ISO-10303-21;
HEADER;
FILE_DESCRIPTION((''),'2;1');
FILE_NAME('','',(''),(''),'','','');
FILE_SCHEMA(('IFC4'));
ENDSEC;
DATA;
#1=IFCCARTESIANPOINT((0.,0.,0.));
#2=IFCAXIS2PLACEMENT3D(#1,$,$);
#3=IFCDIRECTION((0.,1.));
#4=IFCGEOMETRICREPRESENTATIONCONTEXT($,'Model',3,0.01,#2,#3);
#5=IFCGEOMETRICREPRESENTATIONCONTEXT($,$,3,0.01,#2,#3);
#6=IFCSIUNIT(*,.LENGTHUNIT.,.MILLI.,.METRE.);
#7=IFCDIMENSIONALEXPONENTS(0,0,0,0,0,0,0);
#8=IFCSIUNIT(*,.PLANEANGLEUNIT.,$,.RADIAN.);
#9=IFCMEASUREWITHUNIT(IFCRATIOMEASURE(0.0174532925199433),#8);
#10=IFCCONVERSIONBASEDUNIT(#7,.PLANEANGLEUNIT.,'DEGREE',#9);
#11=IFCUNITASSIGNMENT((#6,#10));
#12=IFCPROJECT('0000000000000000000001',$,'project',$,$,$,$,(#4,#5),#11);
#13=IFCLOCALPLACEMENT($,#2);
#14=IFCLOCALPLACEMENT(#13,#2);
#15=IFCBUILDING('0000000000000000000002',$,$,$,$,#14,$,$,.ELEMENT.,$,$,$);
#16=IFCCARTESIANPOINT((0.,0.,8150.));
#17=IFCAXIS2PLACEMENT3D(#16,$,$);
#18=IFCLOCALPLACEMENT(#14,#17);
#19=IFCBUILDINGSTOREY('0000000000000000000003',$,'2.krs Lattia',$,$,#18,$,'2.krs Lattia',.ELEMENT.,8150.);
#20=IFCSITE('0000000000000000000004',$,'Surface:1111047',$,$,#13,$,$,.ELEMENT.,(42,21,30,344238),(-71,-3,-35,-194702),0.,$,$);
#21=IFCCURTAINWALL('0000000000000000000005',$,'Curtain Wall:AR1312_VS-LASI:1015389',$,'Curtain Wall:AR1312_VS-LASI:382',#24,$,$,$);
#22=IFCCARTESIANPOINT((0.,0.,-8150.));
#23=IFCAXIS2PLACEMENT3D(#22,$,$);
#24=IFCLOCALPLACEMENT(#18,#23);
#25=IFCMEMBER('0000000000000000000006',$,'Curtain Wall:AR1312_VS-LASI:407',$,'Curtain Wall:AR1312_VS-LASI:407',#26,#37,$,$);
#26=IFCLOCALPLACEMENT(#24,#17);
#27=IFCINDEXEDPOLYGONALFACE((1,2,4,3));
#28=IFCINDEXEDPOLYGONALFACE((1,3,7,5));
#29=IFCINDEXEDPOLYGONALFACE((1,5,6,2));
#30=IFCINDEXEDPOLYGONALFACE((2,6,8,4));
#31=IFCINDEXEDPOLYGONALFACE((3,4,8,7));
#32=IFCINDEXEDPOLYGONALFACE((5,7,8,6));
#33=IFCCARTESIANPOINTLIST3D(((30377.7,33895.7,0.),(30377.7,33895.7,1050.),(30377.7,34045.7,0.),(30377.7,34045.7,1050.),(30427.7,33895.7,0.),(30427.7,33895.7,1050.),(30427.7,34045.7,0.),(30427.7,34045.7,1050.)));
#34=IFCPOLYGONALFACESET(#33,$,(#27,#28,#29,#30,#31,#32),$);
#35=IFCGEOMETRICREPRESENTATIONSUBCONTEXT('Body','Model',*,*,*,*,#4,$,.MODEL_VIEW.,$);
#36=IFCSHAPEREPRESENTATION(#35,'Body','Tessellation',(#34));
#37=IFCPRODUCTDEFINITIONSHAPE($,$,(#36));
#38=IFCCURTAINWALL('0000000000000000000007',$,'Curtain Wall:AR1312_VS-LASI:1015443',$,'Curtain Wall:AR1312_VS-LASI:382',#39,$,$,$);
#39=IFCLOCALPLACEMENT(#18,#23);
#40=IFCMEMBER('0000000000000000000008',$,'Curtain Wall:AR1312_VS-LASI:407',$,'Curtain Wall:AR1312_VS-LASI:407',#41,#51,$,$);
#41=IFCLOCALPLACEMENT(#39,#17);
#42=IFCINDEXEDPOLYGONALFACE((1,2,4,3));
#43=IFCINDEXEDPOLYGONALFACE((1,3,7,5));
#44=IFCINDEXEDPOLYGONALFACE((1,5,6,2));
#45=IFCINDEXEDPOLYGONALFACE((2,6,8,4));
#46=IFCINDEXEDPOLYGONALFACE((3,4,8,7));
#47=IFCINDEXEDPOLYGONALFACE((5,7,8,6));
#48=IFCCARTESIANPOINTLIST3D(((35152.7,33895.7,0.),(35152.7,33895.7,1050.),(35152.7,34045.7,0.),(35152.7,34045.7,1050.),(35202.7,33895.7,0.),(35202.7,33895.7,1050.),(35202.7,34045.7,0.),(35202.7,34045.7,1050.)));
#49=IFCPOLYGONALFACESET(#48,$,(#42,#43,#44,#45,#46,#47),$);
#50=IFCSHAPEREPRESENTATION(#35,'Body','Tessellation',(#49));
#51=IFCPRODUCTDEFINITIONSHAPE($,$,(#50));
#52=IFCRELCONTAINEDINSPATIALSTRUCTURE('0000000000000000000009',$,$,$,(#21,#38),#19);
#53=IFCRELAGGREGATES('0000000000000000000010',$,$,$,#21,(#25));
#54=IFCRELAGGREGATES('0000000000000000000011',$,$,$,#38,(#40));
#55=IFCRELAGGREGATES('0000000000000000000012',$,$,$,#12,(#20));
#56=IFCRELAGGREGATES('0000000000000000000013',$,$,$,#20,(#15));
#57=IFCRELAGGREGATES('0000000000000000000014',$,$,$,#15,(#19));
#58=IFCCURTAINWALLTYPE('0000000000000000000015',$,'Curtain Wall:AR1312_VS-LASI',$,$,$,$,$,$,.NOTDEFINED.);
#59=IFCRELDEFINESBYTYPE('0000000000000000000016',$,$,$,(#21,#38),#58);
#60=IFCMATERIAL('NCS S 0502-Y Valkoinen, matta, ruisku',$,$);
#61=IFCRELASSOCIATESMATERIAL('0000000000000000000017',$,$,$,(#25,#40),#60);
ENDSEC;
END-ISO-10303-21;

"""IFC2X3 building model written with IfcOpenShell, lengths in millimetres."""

from ifc_helpers import new_model, entity, si_unit, converted_unit, direction, frame, frame_2d, origin, place, context, subcontext, project, spatial, rectangle, extrude, material, type_object, element, aggregate, save


model = new_model("IFC2X3")

# Units and contexts
model_context = context("Model", 3, precision=0.01, world=origin(), true_north=direction((0.0, 1.0)))
context_of_model = context(None, 3, precision=0.01, world=origin(), true_north=direction((0.0, 1.0)))
body_context = subcontext(model_context, "Body", "Model", "MODEL_VIEW")
ifc_project = project(units=[si_unit("LENGTHUNIT", "METRE", prefix="MILLI"), converted_unit("PLANEANGLEUNIT", "DEGREE", entity("IfcRatioMeasure", 0.0174532925199433), si_unit("PLANEANGLEUNIT", "RADIAN"), dimensions=[0, 0, 0, 0, 0, 0, 0])], contexts=[model_context, context_of_model])

# Site, building, storey
site_placement = place(None, origin())
site = spatial("IfcSite", under=ifc_project, at=site_placement, Name="Surface:1111047", CompositionType="ELEMENT", RefLatitude=(42, 21, 30, 344238), RefLongitude=(-71, -3, -35, -194702), RefElevation=0.0)
building_placement = place(site_placement, origin())
building = spatial("IfcBuilding", under=site, at=building_placement, CompositionType="ELEMENT")
storey_placement = place(building_placement, frame((0.0, 0.0, 8150.0)))
storey = spatial("IfcBuildingStorey", under=building, at=storey_placement, Name="2.krs Lattia", LongName="2.krs Lattia", CompositionType="ELEMENT", Elevation=8150.0)

# Curtain walls, members
curtain_wall_type = type_object("IfcCurtainWallType", Name="Curtain Wall:AR1312_VS-LASI", PredefinedType="NOTDEFINED")
ifc_material_1 = material(Name="NCS S 0502-Y Valkoinen, matta, ruisku")
curtain_wall_1_placement = place(storey_placement, frame((0.0, 0.0, -8150.0)))
curtain_wall_1 = element("IfcCurtainWall", 1, at=curtain_wall_1_placement, inside=storey, type_object=curtain_wall_type, Name="Curtain Wall:AR1312_VS-LASI:1015389", ObjectType="Curtain Wall:AR1312_VS-LASI:382")
member_1_placement = place(curtain_wall_1_placement, frame((0.0, 0.0, 8150.0)))
member_1 = element("IfcMember", 2, at=member_1_placement, material=ifc_material_1, Name="Curtain Wall:AR1312_VS-LASI:407", ObjectType="Curtain Wall:AR1312_VS-LASI:407", context=body_context, shape_type="SweptSolid", body=[
    extrude(rectangle(XDim=50.0, YDim=150.0, at=frame_2d((0.0, 0.0), x_axis=(1.0, 0.0))), frame((30402.7, 33970.7, 0.0), z_axis=(0.0, 0.0, 1.0), x_axis=(-1.0, 0.0, 0.0)), (0.0, 0.0, 1.0), 1050.0),
])
aggregate(curtain_wall_1, [member_1])
curtain_wall_2_placement = place(storey_placement, frame((0.0, 0.0, -8150.0)))
curtain_wall_2 = element("IfcCurtainWall", 3, at=curtain_wall_2_placement, inside=storey, type_object=curtain_wall_type, Name="Curtain Wall:AR1312_VS-LASI:1015443", ObjectType="Curtain Wall:AR1312_VS-LASI:382")
member_2_placement = place(curtain_wall_2_placement, frame((0.0, 0.0, 8150.0)))
member_2 = element("IfcMember", 4, at=member_2_placement, material=ifc_material_1, Name="Curtain Wall:AR1312_VS-LASI:407", ObjectType="Curtain Wall:AR1312_VS-LASI:407", context=body_context, shape_type="SweptSolid", body=[
    extrude(rectangle(XDim=50.0, YDim=150.0, at=frame_2d((0.0, 0.0), x_axis=(1.0, 0.0))), frame((35177.7, 33970.7, 0.0), z_axis=(0.0, 0.0, 1.0), x_axis=(-1.0, 0.0, 0.0)), (0.0, 0.0, 1.0), 1050.0),
])
aggregate(curtain_wall_2, [member_2])

save(model, "model.ifc")
